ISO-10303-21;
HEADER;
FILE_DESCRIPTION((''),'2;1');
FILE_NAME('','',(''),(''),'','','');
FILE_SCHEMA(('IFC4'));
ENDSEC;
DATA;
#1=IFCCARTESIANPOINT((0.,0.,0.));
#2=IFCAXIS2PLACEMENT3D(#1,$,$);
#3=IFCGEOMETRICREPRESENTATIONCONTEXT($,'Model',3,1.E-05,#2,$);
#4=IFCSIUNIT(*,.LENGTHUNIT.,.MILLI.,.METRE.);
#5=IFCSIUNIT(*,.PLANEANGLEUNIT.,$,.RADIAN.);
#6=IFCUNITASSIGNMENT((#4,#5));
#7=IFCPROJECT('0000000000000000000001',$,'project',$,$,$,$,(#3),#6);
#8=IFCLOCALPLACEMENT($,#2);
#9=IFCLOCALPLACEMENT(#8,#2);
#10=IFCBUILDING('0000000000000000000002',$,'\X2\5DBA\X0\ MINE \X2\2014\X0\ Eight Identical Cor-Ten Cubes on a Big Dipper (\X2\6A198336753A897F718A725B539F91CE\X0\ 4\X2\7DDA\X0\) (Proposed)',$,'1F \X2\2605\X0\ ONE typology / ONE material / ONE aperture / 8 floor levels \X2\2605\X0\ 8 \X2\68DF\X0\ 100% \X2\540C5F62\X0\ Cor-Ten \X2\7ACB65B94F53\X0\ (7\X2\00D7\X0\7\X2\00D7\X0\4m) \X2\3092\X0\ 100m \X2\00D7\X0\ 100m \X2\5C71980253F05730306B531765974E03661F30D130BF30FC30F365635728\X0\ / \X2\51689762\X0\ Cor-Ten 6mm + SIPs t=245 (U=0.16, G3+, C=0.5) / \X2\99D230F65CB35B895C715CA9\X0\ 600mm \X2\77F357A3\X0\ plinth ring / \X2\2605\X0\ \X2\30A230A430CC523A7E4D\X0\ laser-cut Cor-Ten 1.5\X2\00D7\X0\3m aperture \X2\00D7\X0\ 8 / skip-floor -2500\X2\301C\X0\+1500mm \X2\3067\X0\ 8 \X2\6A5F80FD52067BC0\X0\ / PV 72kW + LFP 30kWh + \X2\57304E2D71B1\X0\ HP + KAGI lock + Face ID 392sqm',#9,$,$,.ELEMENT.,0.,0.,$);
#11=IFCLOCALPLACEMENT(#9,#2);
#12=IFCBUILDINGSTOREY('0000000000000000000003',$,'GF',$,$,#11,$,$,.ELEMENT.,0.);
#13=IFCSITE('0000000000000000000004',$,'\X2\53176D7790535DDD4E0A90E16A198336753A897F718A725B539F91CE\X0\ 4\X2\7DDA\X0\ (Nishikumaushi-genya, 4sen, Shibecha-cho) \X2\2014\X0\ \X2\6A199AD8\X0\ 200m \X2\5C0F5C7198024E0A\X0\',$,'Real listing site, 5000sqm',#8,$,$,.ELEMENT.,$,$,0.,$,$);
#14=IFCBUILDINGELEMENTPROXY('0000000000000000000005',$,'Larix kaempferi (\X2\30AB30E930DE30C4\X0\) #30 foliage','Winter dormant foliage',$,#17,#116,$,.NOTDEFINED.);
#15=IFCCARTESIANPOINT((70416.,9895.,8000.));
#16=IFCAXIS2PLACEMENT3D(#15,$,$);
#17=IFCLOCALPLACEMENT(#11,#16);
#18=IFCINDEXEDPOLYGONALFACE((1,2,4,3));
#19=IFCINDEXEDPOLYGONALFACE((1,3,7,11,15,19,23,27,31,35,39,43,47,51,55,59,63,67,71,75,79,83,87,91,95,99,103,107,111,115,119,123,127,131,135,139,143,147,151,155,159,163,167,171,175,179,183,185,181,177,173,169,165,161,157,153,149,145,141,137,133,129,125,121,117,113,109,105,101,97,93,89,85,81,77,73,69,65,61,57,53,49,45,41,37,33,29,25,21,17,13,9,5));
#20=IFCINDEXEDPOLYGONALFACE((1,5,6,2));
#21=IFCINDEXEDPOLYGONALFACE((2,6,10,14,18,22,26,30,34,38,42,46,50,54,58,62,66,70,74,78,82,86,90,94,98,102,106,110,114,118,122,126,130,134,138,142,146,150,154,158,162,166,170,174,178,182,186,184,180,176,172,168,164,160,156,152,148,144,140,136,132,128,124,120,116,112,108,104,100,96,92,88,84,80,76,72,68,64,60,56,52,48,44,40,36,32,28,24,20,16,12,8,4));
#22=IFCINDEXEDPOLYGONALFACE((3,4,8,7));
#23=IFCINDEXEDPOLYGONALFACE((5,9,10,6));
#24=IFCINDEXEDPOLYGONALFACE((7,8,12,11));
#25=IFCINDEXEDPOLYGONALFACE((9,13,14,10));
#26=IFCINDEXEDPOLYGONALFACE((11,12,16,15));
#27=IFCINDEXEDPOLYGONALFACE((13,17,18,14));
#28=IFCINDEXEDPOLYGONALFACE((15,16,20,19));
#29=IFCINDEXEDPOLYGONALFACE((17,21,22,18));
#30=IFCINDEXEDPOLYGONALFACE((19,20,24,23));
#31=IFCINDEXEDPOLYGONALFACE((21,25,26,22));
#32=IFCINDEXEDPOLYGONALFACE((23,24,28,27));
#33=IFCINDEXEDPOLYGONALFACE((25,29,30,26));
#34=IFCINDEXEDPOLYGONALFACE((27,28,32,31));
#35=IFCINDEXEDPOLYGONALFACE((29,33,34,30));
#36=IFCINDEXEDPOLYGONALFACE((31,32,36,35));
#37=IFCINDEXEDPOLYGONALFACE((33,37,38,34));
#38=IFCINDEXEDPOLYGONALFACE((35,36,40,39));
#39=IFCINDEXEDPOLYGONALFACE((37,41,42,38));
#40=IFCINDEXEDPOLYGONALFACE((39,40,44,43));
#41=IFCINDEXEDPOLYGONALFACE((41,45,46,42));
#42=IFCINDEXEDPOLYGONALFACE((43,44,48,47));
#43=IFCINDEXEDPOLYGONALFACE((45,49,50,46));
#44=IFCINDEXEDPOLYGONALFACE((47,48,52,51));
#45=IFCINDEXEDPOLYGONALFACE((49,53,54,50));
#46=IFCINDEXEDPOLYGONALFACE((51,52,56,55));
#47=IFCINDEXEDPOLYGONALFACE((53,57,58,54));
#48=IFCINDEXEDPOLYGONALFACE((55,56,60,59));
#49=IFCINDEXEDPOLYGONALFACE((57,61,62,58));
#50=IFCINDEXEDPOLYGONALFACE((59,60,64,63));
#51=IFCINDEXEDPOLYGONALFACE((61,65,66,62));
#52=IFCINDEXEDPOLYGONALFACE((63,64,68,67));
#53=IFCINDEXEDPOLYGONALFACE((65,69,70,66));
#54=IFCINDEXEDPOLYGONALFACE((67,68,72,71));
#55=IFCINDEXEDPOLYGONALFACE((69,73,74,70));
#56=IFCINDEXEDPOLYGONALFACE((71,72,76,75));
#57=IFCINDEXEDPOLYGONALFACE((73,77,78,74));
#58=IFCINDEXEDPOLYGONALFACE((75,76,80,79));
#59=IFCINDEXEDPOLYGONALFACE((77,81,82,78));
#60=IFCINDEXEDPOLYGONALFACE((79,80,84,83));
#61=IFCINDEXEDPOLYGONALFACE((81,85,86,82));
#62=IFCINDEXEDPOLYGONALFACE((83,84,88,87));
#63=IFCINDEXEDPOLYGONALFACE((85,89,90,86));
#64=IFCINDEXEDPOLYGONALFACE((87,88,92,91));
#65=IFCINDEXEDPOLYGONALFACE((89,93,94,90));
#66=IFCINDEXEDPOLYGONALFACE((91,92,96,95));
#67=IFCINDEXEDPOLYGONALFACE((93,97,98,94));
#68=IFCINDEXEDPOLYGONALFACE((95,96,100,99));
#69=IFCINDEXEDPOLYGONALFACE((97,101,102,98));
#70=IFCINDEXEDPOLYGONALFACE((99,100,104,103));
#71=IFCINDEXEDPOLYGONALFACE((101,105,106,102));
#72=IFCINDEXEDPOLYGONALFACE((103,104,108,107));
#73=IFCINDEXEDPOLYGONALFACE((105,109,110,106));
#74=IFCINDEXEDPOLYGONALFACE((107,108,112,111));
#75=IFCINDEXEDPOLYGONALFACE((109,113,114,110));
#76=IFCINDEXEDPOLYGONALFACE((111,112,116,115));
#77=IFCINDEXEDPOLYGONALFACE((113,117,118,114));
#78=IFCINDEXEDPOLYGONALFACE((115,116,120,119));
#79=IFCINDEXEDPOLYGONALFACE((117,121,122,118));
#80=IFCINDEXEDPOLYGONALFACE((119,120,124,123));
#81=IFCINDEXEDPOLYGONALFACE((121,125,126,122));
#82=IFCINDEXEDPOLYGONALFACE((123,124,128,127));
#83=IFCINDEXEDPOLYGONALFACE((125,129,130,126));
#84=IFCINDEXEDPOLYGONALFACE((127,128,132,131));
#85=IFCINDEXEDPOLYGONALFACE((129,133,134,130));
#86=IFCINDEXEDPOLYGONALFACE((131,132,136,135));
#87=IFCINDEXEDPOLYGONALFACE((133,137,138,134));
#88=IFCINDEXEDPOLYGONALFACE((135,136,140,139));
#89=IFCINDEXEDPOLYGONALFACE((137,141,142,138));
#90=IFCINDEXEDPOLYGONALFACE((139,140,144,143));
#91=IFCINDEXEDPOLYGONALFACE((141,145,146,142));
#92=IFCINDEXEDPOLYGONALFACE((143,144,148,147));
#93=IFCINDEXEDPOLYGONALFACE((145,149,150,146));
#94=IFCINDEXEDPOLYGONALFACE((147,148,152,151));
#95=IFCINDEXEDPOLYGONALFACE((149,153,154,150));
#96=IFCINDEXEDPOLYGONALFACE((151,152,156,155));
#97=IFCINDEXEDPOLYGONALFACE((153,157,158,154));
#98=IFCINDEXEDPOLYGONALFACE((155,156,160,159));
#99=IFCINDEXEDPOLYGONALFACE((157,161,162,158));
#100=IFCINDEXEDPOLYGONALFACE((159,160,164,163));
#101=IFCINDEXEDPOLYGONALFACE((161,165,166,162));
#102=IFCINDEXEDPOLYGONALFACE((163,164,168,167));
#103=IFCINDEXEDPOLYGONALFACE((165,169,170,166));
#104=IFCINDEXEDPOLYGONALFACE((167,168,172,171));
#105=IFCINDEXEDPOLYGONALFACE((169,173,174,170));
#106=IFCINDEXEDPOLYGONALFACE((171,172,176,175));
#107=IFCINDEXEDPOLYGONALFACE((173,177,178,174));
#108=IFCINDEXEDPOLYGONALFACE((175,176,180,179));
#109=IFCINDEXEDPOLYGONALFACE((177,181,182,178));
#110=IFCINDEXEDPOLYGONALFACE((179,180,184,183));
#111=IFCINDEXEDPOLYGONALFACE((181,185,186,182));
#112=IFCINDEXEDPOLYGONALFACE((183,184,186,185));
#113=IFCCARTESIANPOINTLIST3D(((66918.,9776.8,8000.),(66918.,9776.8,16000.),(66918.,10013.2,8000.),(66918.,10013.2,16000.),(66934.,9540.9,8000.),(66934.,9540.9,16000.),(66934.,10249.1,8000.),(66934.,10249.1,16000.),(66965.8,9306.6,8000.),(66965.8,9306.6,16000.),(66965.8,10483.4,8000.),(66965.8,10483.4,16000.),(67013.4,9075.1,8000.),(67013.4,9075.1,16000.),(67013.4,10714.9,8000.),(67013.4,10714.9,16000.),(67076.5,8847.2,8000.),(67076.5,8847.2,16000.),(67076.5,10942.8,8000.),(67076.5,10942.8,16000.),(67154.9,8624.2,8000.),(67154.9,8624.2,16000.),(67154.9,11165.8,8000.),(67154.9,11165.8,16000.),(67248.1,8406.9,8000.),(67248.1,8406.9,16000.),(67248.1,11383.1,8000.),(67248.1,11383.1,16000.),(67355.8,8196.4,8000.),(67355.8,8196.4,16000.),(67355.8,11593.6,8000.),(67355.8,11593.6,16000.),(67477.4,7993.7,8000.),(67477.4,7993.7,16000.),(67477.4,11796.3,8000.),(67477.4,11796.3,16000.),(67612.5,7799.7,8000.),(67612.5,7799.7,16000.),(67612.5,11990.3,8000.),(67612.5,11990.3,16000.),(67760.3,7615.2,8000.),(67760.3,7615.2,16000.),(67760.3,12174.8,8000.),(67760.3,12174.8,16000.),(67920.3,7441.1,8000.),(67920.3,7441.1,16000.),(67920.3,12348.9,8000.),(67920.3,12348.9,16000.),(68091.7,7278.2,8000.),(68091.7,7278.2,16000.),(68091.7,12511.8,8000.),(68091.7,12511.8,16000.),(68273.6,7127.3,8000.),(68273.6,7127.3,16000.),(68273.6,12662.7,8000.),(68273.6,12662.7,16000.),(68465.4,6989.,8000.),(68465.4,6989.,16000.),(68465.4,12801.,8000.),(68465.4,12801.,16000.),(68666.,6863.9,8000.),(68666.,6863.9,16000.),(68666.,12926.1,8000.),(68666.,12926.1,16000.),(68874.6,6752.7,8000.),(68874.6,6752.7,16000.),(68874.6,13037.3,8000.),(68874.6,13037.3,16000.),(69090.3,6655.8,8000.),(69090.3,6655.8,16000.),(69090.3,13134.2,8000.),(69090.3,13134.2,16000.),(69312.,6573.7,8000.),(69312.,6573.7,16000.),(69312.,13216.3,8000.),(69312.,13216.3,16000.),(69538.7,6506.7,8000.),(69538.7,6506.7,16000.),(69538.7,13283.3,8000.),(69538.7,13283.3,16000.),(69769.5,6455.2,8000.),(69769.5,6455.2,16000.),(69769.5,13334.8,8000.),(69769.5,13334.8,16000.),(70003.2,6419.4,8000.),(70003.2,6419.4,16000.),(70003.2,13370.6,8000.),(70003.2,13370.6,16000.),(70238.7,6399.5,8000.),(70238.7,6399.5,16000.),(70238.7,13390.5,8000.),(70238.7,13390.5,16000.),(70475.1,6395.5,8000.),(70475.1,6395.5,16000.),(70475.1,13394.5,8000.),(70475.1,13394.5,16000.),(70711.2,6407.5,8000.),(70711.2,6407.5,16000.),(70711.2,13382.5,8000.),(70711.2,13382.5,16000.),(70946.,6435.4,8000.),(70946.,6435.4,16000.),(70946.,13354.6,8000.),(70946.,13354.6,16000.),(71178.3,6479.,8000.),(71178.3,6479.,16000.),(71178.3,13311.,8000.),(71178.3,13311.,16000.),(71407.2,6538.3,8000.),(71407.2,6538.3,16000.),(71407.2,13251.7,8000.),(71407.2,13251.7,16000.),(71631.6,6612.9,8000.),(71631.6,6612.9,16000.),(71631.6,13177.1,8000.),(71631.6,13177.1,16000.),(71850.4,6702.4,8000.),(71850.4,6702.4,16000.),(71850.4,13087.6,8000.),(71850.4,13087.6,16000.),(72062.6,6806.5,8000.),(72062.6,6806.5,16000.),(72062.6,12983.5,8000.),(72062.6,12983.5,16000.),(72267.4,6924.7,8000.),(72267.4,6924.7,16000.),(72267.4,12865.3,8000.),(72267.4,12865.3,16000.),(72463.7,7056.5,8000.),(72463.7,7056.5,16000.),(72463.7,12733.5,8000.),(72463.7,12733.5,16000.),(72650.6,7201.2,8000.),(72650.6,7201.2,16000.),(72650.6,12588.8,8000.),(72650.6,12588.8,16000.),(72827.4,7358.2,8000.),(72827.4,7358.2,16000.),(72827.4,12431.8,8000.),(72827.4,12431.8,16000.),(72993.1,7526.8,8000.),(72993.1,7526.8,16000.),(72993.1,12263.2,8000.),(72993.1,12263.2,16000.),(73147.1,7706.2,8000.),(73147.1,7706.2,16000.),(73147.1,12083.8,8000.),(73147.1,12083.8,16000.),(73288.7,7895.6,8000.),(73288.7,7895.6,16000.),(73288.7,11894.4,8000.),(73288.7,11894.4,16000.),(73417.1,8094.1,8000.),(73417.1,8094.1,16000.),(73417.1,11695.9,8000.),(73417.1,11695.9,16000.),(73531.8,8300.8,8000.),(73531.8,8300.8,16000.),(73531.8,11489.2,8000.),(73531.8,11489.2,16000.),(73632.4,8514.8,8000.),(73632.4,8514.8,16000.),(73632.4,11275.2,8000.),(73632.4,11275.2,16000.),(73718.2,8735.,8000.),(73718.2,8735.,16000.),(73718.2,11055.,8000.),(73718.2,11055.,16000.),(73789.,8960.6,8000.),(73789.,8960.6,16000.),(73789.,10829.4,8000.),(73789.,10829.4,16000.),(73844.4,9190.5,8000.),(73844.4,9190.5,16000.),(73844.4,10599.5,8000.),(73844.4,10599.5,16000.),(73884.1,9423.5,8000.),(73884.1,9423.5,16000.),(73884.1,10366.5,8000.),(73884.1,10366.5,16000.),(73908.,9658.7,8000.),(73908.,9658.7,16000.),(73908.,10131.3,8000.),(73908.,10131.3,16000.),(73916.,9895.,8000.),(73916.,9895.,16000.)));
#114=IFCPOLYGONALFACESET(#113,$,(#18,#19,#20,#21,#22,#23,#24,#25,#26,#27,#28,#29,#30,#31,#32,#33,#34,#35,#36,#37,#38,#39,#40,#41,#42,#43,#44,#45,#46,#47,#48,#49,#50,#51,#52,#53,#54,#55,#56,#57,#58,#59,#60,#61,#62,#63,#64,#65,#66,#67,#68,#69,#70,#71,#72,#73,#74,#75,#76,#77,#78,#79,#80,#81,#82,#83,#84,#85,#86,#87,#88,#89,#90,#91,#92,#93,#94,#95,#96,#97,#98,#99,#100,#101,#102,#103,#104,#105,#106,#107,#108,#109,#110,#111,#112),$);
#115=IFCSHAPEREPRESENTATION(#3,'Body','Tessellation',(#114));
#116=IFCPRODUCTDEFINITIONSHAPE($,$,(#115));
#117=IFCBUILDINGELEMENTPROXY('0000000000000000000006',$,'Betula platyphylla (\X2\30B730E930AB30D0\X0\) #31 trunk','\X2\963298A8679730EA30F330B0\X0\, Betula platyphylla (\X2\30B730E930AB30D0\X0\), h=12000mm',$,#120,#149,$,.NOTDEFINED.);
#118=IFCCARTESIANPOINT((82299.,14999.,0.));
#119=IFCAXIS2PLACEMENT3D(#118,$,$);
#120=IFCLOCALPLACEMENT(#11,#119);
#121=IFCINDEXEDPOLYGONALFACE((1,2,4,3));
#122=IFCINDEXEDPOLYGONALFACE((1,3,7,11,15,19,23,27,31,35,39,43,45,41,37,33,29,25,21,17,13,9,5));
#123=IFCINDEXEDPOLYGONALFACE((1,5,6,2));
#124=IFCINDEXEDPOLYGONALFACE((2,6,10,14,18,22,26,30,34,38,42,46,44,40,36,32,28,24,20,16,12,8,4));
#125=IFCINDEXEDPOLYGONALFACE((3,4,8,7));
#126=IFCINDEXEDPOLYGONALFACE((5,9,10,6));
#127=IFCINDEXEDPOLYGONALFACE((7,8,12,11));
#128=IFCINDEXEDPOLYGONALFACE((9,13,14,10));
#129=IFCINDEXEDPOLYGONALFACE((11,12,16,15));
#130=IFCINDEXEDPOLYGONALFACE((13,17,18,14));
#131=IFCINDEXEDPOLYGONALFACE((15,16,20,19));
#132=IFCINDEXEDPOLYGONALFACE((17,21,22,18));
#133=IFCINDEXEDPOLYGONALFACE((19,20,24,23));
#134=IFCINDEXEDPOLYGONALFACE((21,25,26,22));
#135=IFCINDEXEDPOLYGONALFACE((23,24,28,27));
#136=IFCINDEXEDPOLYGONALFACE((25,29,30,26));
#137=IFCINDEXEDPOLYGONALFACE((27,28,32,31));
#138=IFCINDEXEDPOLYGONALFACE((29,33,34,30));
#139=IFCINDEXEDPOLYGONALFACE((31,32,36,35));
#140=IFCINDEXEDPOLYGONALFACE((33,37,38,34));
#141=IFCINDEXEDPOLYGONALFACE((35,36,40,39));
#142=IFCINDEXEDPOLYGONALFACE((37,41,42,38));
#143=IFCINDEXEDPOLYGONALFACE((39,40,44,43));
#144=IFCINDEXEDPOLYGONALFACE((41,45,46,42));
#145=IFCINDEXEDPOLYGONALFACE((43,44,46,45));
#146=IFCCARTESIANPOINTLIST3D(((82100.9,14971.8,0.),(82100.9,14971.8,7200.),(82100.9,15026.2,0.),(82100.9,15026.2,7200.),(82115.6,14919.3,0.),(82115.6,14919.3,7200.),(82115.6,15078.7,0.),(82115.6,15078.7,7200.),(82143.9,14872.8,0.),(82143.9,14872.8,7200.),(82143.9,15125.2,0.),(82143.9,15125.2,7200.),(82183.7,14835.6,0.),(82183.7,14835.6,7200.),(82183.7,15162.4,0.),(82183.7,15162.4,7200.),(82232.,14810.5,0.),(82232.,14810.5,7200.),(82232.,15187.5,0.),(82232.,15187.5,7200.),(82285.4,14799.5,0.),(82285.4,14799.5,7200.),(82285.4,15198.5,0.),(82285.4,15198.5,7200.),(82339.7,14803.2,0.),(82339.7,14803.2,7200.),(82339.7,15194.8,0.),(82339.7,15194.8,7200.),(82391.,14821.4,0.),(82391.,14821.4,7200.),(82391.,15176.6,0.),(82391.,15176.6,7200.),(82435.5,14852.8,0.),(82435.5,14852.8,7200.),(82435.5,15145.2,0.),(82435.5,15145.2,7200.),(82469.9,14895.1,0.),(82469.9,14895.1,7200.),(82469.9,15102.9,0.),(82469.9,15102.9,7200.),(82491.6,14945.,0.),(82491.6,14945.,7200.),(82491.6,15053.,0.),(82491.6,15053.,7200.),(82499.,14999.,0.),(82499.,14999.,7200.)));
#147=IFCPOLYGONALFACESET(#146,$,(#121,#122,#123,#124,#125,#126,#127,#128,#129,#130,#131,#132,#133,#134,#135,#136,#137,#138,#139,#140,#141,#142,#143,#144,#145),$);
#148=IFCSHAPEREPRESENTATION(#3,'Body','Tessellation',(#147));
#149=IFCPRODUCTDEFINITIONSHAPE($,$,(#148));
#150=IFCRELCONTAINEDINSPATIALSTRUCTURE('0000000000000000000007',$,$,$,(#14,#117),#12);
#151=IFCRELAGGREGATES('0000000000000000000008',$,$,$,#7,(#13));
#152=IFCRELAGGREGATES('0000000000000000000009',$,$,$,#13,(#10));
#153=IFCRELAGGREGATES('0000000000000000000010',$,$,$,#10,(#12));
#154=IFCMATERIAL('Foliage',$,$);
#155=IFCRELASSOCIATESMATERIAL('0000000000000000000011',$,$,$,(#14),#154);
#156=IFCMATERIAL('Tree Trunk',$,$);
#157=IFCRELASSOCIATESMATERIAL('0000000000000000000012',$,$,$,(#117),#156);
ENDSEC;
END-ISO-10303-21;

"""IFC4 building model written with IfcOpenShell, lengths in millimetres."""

from ifc_helpers import new_model, si_unit, frame, origin, origin_2d, place, context, project, spatial, circle, extrude, material, element, save


model = new_model("IFC4")

# Units and contexts
model_context = context("Model", 3, precision=1e-05, world=origin())
ifc_project = project(units=[si_unit("LENGTHUNIT", "METRE", prefix="MILLI"), si_unit("PLANEANGLEUNIT", "RADIAN")], contexts=[model_context])

# Site, building, storey
site_placement = place(None, origin())
site = spatial("IfcSite", under=ifc_project, at=site_placement, Name="北海道川上郡標茶町西熊牛原野 4線 (Nishikumaushi-genya, 4sen, Shibecha-cho) — 標高 200m 小山頂上", ObjectType="Real listing site, 5000sqm", CompositionType="ELEMENT", RefElevation=0.0)
building_placement = place(site_placement, origin())
building = spatial("IfcBuilding", under=site, at=building_placement, Name="嶺 MINE — Eight Identical Cor-Ten Cubes on a Big Dipper (標茶町西熊牛原野 4線) (Proposed)", ObjectType="1F ★ ONE typology / ONE material / ONE aperture / 8 floor levels ★ 8 棟 100% 同形 Cor-Ten 立方体 (7×7×4m) を 100m × 100m 山頂台地に北斗七星パターン散在 / 全面 Cor-Ten 6mm + SIPs t=245 (U=0.16, G3+, C=0.5) / 駒ヶ岳安山岩 600mm 石垣 plinth ring / ★ アイヌ刺繍 laser-cut Cor-Ten 1.5×3m aperture × 8 / skip-floor -2500〜+1500mm で 8 機能分節 / PV 72kW + LFP 30kWh + 地中熱 HP + KAGI lock + Face ID 392sqm", CompositionType="ELEMENT", ElevationOfRefHeight=0.0, ElevationOfTerrain=0.0)
storey_placement = place(building_placement, origin())
storey = spatial("IfcBuildingStorey", under=building, at=storey_placement, Name="GF", CompositionType="ELEMENT", Elevation=0.0)

# Building element proxies
ifc_material_1 = material(Name="Tree Trunk")
ifc_material_2 = material(Name="Foliage")
proxy_1_placement = place(storey_placement, frame((70416.0, 9895.0, 8000.0)))
element("IfcBuildingElementProxy", 1, at=proxy_1_placement, inside=storey, material=ifc_material_2, Name="Larix kaempferi (カラマツ) #30 foliage", Description="Winter dormant foliage", PredefinedType="NOTDEFINED", context=model_context, shape_type="SweptSolid", body=[
    extrude(circle(Radius=3500.0, at=origin_2d()), frame((70416.0, 9895.0, 8000.0)), (0.0, 0.0, 1.0), 8000.0),
])
proxy_2_placement = place(storey_placement, frame((82299.0, 14999.0, 0.0)))
element("IfcBuildingElementProxy", 2, at=proxy_2_placement, inside=storey, material=ifc_material_1, Name="Betula platyphylla (シラカバ) #31 trunk", Description="防風林リング, Betula platyphylla (シラカバ), h=12000mm", PredefinedType="NOTDEFINED", context=model_context, shape_type="SweptSolid", body=[
    extrude(circle(Radius=200.0, at=origin_2d()), frame((82299.0, 14999.0, 0.0)), (0.0, 0.0, 1.0), 7200.0),
])

save(model, "model.ifc")
